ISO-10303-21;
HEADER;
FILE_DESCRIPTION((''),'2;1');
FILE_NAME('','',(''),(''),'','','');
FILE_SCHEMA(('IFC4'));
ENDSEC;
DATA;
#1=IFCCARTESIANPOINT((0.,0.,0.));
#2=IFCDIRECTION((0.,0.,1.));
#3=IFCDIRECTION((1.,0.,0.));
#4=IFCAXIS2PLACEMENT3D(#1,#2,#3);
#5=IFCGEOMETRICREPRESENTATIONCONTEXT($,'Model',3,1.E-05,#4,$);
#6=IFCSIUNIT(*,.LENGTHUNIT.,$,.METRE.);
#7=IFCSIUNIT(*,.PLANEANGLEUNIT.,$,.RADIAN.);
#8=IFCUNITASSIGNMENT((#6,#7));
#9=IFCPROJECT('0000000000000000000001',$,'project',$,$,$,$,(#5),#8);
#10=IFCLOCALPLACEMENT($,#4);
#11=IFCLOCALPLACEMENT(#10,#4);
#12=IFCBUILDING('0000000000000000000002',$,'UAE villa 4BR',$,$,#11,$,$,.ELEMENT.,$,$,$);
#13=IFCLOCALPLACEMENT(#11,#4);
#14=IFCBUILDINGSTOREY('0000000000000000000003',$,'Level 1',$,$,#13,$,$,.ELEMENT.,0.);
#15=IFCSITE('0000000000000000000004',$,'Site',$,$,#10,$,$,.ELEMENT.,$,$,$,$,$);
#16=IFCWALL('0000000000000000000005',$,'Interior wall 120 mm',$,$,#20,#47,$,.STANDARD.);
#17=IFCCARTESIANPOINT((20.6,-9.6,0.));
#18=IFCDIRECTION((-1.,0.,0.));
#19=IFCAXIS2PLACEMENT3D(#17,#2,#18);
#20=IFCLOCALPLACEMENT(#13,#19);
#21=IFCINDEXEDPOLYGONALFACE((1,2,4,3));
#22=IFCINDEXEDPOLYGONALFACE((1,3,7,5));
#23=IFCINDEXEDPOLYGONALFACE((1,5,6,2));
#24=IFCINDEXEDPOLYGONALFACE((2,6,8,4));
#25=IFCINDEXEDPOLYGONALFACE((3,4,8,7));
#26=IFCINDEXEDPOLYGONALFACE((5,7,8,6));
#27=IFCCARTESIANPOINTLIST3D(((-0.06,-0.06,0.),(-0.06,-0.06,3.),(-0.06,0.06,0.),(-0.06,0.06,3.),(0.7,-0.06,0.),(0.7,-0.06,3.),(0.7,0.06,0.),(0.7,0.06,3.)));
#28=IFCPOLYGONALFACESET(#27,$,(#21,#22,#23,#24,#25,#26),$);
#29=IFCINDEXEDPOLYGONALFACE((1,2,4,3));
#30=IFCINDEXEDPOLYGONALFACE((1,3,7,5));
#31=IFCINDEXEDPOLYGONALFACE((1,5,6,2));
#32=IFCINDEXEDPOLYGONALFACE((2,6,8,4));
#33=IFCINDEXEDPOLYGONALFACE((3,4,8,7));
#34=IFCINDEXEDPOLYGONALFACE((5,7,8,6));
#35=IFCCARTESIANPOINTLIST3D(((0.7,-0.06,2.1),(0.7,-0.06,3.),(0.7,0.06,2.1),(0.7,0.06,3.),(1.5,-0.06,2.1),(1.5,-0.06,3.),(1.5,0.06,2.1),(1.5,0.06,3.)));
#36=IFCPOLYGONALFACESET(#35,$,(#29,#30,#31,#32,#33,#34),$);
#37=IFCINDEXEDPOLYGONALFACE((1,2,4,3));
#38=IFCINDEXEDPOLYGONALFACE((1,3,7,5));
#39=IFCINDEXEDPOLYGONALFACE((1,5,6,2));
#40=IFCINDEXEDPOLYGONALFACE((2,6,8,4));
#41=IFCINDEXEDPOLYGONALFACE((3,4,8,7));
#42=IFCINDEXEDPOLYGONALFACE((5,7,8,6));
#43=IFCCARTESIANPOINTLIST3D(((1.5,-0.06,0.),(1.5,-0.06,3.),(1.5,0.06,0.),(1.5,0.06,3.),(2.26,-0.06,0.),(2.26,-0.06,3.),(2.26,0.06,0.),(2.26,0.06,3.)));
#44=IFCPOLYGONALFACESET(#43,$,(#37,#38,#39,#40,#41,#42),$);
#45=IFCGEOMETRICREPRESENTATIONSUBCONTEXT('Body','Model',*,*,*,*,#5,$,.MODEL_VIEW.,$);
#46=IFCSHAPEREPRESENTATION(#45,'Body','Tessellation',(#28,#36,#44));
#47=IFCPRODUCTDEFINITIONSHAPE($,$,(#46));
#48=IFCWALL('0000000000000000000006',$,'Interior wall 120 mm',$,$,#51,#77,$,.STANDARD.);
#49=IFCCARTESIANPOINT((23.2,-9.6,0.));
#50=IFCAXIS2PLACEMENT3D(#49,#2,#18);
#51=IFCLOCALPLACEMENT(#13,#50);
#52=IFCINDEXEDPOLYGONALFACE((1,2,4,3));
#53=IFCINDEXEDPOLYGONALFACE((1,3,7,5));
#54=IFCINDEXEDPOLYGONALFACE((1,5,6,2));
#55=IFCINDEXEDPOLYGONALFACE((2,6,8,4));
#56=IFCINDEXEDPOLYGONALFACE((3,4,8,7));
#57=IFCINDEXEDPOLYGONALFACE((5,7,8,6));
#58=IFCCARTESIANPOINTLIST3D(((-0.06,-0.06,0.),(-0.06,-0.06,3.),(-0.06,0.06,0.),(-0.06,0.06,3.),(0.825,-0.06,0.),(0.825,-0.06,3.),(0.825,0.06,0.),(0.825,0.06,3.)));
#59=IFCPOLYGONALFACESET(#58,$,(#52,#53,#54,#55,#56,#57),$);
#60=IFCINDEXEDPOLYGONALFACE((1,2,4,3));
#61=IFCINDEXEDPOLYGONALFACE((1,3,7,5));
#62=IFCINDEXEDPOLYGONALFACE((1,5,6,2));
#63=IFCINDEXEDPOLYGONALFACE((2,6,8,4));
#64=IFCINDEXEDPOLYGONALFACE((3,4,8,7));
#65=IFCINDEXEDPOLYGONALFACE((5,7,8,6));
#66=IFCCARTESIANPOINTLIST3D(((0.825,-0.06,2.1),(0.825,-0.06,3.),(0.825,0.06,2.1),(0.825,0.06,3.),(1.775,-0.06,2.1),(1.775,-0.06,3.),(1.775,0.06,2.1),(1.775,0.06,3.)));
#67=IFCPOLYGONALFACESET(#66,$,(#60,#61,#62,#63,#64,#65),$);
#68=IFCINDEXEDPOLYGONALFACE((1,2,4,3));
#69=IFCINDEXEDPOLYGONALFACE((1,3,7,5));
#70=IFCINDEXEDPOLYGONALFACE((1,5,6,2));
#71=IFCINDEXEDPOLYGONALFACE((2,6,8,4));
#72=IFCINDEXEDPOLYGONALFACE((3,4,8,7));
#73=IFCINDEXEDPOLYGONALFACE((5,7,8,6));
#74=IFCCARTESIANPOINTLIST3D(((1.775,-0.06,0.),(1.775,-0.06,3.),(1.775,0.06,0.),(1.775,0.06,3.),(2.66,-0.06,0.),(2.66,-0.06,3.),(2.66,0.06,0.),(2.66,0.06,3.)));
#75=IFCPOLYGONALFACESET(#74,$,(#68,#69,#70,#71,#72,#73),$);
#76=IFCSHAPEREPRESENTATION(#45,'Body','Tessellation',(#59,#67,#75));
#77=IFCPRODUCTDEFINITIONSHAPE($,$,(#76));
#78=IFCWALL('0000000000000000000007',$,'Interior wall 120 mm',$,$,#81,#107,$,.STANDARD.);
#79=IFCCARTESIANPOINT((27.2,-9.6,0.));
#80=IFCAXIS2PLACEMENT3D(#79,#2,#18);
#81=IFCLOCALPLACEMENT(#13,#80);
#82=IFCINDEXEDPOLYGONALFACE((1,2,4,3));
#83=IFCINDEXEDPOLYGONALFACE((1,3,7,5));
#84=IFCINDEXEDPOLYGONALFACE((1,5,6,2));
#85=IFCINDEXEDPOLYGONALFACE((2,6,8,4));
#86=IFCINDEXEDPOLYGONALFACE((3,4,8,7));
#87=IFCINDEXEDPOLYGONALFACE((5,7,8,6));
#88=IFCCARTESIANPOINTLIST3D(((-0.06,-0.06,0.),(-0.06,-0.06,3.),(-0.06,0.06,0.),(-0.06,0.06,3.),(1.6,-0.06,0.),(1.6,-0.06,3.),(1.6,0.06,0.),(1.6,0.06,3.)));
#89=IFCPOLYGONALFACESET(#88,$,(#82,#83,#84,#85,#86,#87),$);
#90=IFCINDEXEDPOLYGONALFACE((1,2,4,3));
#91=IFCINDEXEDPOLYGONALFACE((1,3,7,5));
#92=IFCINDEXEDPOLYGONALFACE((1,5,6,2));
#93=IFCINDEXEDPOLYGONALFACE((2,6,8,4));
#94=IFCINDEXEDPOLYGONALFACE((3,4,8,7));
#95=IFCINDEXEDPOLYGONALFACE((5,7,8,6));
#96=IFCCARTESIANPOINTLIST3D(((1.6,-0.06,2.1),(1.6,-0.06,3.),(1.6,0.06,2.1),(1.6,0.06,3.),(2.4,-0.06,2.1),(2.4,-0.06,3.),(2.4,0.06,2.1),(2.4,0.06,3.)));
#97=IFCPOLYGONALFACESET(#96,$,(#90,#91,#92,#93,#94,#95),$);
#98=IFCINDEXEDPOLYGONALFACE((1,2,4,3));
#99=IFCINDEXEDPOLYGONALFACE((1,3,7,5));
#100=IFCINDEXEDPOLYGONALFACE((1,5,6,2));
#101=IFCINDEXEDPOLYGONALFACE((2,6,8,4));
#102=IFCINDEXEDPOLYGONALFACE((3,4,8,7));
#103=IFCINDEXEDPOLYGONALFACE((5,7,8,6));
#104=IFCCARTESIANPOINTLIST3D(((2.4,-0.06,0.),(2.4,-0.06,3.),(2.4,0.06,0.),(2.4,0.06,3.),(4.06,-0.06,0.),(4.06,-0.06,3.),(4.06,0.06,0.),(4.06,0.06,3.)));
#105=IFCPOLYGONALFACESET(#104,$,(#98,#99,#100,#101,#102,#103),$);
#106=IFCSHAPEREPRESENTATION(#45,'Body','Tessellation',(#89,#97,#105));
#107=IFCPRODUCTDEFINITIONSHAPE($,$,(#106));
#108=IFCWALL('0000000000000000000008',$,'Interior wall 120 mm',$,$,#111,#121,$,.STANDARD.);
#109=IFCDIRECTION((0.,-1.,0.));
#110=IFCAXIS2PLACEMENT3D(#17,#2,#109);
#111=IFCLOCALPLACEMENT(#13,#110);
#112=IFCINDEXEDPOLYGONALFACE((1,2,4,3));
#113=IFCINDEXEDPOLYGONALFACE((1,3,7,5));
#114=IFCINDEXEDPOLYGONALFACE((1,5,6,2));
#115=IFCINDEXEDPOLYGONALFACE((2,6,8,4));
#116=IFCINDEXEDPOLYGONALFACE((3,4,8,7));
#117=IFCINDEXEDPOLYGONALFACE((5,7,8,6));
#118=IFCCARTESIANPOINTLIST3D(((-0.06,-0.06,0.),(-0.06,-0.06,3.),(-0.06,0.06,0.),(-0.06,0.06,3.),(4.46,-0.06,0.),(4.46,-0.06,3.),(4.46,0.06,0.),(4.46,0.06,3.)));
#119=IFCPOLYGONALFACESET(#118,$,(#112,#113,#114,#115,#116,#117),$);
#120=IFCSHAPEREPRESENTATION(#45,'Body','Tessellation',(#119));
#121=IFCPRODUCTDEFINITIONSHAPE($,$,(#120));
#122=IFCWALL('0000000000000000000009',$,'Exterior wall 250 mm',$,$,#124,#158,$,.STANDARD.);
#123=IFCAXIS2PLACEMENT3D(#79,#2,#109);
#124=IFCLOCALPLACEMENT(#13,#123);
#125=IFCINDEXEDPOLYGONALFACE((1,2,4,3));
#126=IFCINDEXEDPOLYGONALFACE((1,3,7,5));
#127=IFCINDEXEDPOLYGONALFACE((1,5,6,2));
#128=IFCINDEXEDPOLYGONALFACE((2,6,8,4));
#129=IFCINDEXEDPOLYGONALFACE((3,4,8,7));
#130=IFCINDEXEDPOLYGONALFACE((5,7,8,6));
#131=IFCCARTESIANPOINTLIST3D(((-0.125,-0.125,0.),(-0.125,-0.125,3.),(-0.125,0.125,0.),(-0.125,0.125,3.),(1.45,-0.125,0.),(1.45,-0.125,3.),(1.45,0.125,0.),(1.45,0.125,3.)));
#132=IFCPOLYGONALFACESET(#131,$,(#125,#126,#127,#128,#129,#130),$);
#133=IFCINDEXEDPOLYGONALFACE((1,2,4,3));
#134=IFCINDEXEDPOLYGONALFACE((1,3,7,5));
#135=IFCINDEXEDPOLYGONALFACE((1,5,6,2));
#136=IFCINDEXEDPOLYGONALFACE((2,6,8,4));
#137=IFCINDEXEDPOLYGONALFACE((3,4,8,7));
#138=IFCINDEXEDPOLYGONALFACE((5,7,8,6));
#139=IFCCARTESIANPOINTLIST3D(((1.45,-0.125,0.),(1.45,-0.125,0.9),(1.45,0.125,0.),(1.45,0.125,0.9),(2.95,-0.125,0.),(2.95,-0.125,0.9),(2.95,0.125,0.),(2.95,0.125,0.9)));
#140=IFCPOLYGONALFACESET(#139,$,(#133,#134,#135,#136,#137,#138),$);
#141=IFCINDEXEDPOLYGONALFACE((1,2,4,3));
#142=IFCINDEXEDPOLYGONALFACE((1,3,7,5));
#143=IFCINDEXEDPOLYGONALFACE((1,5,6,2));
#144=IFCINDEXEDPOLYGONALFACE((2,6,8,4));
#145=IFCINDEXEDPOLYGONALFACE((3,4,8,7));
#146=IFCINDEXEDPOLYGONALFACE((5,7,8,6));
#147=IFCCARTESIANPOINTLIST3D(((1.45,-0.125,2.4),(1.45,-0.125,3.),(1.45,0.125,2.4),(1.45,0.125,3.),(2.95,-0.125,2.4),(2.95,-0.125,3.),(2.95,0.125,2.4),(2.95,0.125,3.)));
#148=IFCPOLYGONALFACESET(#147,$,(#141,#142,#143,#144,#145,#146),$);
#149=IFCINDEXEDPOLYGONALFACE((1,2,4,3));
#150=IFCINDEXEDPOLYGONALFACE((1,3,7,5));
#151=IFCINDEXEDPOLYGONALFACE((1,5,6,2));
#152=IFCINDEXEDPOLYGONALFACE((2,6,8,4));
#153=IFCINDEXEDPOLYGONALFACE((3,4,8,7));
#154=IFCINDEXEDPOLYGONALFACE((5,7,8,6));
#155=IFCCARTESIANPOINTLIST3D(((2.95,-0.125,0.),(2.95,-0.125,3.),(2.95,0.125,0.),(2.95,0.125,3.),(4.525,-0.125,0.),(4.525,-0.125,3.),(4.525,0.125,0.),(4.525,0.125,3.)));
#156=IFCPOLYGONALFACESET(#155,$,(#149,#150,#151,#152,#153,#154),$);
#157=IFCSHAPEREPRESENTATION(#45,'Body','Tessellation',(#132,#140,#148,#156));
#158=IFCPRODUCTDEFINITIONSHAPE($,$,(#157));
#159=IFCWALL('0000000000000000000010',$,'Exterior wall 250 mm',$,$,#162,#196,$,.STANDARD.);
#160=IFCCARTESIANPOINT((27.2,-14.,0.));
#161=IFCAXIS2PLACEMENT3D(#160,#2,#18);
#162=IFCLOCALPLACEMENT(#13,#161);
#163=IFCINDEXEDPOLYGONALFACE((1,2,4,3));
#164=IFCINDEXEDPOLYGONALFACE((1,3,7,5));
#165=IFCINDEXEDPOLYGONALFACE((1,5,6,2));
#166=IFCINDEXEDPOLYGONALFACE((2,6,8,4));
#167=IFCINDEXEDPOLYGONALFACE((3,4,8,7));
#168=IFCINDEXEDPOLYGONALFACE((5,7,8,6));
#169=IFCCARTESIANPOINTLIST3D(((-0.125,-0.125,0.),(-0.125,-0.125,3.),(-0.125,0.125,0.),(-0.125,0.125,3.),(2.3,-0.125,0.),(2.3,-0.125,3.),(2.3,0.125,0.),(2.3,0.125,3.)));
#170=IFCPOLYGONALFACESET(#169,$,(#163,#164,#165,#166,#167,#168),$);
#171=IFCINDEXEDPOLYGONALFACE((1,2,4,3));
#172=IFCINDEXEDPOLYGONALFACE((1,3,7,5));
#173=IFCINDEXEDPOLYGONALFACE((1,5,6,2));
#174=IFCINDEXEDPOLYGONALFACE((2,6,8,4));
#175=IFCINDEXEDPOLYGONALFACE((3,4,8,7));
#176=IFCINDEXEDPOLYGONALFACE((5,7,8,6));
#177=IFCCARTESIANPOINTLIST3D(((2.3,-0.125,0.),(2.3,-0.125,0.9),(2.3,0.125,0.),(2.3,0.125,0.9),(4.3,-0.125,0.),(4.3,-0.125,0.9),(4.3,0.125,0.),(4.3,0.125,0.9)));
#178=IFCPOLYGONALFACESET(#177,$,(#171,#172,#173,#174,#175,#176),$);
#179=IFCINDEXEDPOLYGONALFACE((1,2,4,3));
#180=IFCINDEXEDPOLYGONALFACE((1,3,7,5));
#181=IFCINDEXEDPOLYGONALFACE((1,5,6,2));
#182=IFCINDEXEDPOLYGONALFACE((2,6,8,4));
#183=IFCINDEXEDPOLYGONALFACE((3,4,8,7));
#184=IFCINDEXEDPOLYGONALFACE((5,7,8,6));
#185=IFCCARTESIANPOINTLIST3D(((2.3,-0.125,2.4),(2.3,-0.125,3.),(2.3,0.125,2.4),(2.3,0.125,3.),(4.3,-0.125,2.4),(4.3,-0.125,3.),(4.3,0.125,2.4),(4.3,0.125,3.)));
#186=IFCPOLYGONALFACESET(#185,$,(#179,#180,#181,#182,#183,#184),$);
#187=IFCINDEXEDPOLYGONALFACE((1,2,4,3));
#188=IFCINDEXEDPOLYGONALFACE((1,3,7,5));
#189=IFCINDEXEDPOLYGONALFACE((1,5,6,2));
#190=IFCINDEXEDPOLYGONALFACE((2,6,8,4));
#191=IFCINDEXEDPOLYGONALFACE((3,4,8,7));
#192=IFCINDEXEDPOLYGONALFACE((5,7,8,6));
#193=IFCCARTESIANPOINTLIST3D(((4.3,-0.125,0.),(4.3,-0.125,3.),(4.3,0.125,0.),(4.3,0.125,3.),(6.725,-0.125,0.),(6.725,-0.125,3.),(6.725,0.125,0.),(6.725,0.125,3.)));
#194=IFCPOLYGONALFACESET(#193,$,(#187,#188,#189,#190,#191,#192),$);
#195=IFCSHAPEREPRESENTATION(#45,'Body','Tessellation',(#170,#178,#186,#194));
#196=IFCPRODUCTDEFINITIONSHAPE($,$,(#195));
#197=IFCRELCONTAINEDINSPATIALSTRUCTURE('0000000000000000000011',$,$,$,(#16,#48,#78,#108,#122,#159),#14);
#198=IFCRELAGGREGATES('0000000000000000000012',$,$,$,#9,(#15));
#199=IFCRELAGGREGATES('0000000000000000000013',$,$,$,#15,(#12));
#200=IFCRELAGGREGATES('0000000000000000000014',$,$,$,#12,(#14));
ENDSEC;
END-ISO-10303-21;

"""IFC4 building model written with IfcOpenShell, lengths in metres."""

from ifc_helpers import new_model, si_unit, frame, origin_with_axes, origin_2d, place, context, subcontext, project, spatial, rectangle, extrude, element, save


model = new_model("IFC4")

# Units and contexts
model_context = context("Model", 3, precision=1e-05, world=origin_with_axes())
body_context = subcontext(model_context, "Body", "Model", "MODEL_VIEW")
ifc_project = project(units=[si_unit("LENGTHUNIT", "METRE"), si_unit("PLANEANGLEUNIT", "RADIAN")], contexts=[model_context])

# Site, building, storey
site_placement = place(None, origin_with_axes())
site = spatial("IfcSite", under=ifc_project, at=site_placement, Name="Site", CompositionType="ELEMENT")
building_placement = place(site_placement, origin_with_axes())
building = spatial("IfcBuilding", under=site, at=building_placement, Name="UAE villa 4BR", CompositionType="ELEMENT")
storey_placement = place(building_placement, origin_with_axes())
storey = spatial("IfcBuildingStorey", under=building, at=storey_placement, Name="Level 1", CompositionType="ELEMENT", Elevation=0.0)

# Walls
wall_1_placement = place(storey_placement, frame((20.6, -9.6, 0.0), z_axis=(0.0, 0.0, 1.0), x_axis=(-1.0, 0.0, 0.0)))
element("IfcWall", 1, at=wall_1_placement, inside=storey, Name="Interior wall 120 mm", PredefinedType="STANDARD", context=body_context, shape_type="SweptSolid", body=[
    extrude(rectangle(XDim=0.76, YDim=0.12, at=origin_2d()), frame((0.32, 0.0, 0.0)), (0.0, 0.0, 1.0), 3.0),
    extrude(rectangle(XDim=0.8, YDim=0.12, at=origin_2d()), frame((1.1, 0.0, 2.1)), (0.0, 0.0, 1.0), 0.9),
    extrude(rectangle(XDim=0.76, YDim=0.12, at=origin_2d()), frame((1.88, 0.0, 0.0)), (0.0, 0.0, 1.0), 3.0),
])
wall_2_placement = place(storey_placement, frame((23.2, -9.6, 0.0), z_axis=(0.0, 0.0, 1.0), x_axis=(-1.0, 0.0, 0.0)))
element("IfcWall", 2, at=wall_2_placement, inside=storey, Name="Interior wall 120 mm", PredefinedType="STANDARD", context=body_context, shape_type="SweptSolid", body=[
    extrude(rectangle(XDim=0.885, YDim=0.12, at=origin_2d()), frame((0.3825, 0.0, 0.0)), (0.0, 0.0, 1.0), 3.0),
    extrude(rectangle(XDim=0.95, YDim=0.12, at=origin_2d()), frame((1.3, 0.0, 2.1)), (0.0, 0.0, 1.0), 0.9),
    extrude(rectangle(XDim=0.885, YDim=0.12, at=origin_2d()), frame((2.2175, 0.0, 0.0)), (0.0, 0.0, 1.0), 3.0),
])
wall_3_placement = place(storey_placement, frame((27.2, -9.6, 0.0), z_axis=(0.0, 0.0, 1.0), x_axis=(-1.0, 0.0, 0.0)))
element("IfcWall", 3, at=wall_3_placement, inside=storey, Name="Interior wall 120 mm", PredefinedType="STANDARD", context=body_context, shape_type="SweptSolid", body=[
    extrude(rectangle(XDim=1.66, YDim=0.12, at=origin_2d()), frame((0.77, 0.0, 0.0)), (0.0, 0.0, 1.0), 3.0),
    extrude(rectangle(XDim=0.8, YDim=0.12, at=origin_2d()), frame((2.0, 0.0, 2.1)), (0.0, 0.0, 1.0), 0.9),
    extrude(rectangle(XDim=1.66, YDim=0.12, at=origin_2d()), frame((3.23, 0.0, 0.0)), (0.0, 0.0, 1.0), 3.0),
])
wall_4_placement = place(storey_placement, frame((20.6, -9.6, 0.0), z_axis=(0.0, 0.0, 1.0), x_axis=(0.0, -1.0, 0.0)))
element("IfcWall", 4, at=wall_4_placement, inside=storey, Name="Interior wall 120 mm", PredefinedType="STANDARD", context=body_context, shape_type="SweptSolid", body=[
    extrude(rectangle(XDim=4.52, YDim=0.12, at=origin_2d()), frame((2.2, 0.0, 0.0)), (0.0, 0.0, 1.0), 3.0),
])
wall_5_placement = place(storey_placement, frame((27.2, -9.6, 0.0), z_axis=(0.0, 0.0, 1.0), x_axis=(0.0, -1.0, 0.0)))
element("IfcWall", 5, at=wall_5_placement, inside=storey, Name="Exterior wall 250 mm", PredefinedType="STANDARD", context=body_context, shape_type="SweptSolid", body=[
    extrude(rectangle(XDim=1.575, YDim=0.25, at=origin_2d()), frame((0.6625, 0.0, 0.0)), (0.0, 0.0, 1.0), 3.0),
    extrude(rectangle(XDim=1.5, YDim=0.25, at=origin_2d()), frame((2.2, 0.0, 0.0)), (0.0, 0.0, 1.0), 0.9),
    extrude(rectangle(XDim=1.5, YDim=0.25, at=origin_2d()), frame((2.2, 0.0, 2.4)), (0.0, 0.0, 1.0), 0.6),
    extrude(rectangle(XDim=1.575, YDim=0.25, at=origin_2d()), frame((3.7375, 0.0, 0.0)), (0.0, 0.0, 1.0), 3.0),
])
wall_6_placement = place(storey_placement, frame((27.2, -14.0, 0.0), z_axis=(0.0, 0.0, 1.0), x_axis=(-1.0, 0.0, 0.0)))
element("IfcWall", 6, at=wall_6_placement, inside=storey, Name="Exterior wall 250 mm", PredefinedType="STANDARD", context=body_context, shape_type="SweptSolid", body=[
    extrude(rectangle(XDim=2.425, YDim=0.25, at=origin_2d()), frame((1.0875, 0.0, 0.0)), (0.0, 0.0, 1.0), 3.0),
    extrude(rectangle(XDim=2.0, YDim=0.25, at=origin_2d()), frame((3.3, 0.0, 0.0)), (0.0, 0.0, 1.0), 0.9),
    extrude(rectangle(XDim=2.0, YDim=0.25, at=origin_2d()), frame((3.3, 0.0, 2.4)), (0.0, 0.0, 1.0), 0.6),
    extrude(rectangle(XDim=2.425, YDim=0.25, at=origin_2d()), frame((5.5125, 0.0, 0.0)), (0.0, 0.0, 1.0), 3.0),
])

save(model, "model.ifc")
